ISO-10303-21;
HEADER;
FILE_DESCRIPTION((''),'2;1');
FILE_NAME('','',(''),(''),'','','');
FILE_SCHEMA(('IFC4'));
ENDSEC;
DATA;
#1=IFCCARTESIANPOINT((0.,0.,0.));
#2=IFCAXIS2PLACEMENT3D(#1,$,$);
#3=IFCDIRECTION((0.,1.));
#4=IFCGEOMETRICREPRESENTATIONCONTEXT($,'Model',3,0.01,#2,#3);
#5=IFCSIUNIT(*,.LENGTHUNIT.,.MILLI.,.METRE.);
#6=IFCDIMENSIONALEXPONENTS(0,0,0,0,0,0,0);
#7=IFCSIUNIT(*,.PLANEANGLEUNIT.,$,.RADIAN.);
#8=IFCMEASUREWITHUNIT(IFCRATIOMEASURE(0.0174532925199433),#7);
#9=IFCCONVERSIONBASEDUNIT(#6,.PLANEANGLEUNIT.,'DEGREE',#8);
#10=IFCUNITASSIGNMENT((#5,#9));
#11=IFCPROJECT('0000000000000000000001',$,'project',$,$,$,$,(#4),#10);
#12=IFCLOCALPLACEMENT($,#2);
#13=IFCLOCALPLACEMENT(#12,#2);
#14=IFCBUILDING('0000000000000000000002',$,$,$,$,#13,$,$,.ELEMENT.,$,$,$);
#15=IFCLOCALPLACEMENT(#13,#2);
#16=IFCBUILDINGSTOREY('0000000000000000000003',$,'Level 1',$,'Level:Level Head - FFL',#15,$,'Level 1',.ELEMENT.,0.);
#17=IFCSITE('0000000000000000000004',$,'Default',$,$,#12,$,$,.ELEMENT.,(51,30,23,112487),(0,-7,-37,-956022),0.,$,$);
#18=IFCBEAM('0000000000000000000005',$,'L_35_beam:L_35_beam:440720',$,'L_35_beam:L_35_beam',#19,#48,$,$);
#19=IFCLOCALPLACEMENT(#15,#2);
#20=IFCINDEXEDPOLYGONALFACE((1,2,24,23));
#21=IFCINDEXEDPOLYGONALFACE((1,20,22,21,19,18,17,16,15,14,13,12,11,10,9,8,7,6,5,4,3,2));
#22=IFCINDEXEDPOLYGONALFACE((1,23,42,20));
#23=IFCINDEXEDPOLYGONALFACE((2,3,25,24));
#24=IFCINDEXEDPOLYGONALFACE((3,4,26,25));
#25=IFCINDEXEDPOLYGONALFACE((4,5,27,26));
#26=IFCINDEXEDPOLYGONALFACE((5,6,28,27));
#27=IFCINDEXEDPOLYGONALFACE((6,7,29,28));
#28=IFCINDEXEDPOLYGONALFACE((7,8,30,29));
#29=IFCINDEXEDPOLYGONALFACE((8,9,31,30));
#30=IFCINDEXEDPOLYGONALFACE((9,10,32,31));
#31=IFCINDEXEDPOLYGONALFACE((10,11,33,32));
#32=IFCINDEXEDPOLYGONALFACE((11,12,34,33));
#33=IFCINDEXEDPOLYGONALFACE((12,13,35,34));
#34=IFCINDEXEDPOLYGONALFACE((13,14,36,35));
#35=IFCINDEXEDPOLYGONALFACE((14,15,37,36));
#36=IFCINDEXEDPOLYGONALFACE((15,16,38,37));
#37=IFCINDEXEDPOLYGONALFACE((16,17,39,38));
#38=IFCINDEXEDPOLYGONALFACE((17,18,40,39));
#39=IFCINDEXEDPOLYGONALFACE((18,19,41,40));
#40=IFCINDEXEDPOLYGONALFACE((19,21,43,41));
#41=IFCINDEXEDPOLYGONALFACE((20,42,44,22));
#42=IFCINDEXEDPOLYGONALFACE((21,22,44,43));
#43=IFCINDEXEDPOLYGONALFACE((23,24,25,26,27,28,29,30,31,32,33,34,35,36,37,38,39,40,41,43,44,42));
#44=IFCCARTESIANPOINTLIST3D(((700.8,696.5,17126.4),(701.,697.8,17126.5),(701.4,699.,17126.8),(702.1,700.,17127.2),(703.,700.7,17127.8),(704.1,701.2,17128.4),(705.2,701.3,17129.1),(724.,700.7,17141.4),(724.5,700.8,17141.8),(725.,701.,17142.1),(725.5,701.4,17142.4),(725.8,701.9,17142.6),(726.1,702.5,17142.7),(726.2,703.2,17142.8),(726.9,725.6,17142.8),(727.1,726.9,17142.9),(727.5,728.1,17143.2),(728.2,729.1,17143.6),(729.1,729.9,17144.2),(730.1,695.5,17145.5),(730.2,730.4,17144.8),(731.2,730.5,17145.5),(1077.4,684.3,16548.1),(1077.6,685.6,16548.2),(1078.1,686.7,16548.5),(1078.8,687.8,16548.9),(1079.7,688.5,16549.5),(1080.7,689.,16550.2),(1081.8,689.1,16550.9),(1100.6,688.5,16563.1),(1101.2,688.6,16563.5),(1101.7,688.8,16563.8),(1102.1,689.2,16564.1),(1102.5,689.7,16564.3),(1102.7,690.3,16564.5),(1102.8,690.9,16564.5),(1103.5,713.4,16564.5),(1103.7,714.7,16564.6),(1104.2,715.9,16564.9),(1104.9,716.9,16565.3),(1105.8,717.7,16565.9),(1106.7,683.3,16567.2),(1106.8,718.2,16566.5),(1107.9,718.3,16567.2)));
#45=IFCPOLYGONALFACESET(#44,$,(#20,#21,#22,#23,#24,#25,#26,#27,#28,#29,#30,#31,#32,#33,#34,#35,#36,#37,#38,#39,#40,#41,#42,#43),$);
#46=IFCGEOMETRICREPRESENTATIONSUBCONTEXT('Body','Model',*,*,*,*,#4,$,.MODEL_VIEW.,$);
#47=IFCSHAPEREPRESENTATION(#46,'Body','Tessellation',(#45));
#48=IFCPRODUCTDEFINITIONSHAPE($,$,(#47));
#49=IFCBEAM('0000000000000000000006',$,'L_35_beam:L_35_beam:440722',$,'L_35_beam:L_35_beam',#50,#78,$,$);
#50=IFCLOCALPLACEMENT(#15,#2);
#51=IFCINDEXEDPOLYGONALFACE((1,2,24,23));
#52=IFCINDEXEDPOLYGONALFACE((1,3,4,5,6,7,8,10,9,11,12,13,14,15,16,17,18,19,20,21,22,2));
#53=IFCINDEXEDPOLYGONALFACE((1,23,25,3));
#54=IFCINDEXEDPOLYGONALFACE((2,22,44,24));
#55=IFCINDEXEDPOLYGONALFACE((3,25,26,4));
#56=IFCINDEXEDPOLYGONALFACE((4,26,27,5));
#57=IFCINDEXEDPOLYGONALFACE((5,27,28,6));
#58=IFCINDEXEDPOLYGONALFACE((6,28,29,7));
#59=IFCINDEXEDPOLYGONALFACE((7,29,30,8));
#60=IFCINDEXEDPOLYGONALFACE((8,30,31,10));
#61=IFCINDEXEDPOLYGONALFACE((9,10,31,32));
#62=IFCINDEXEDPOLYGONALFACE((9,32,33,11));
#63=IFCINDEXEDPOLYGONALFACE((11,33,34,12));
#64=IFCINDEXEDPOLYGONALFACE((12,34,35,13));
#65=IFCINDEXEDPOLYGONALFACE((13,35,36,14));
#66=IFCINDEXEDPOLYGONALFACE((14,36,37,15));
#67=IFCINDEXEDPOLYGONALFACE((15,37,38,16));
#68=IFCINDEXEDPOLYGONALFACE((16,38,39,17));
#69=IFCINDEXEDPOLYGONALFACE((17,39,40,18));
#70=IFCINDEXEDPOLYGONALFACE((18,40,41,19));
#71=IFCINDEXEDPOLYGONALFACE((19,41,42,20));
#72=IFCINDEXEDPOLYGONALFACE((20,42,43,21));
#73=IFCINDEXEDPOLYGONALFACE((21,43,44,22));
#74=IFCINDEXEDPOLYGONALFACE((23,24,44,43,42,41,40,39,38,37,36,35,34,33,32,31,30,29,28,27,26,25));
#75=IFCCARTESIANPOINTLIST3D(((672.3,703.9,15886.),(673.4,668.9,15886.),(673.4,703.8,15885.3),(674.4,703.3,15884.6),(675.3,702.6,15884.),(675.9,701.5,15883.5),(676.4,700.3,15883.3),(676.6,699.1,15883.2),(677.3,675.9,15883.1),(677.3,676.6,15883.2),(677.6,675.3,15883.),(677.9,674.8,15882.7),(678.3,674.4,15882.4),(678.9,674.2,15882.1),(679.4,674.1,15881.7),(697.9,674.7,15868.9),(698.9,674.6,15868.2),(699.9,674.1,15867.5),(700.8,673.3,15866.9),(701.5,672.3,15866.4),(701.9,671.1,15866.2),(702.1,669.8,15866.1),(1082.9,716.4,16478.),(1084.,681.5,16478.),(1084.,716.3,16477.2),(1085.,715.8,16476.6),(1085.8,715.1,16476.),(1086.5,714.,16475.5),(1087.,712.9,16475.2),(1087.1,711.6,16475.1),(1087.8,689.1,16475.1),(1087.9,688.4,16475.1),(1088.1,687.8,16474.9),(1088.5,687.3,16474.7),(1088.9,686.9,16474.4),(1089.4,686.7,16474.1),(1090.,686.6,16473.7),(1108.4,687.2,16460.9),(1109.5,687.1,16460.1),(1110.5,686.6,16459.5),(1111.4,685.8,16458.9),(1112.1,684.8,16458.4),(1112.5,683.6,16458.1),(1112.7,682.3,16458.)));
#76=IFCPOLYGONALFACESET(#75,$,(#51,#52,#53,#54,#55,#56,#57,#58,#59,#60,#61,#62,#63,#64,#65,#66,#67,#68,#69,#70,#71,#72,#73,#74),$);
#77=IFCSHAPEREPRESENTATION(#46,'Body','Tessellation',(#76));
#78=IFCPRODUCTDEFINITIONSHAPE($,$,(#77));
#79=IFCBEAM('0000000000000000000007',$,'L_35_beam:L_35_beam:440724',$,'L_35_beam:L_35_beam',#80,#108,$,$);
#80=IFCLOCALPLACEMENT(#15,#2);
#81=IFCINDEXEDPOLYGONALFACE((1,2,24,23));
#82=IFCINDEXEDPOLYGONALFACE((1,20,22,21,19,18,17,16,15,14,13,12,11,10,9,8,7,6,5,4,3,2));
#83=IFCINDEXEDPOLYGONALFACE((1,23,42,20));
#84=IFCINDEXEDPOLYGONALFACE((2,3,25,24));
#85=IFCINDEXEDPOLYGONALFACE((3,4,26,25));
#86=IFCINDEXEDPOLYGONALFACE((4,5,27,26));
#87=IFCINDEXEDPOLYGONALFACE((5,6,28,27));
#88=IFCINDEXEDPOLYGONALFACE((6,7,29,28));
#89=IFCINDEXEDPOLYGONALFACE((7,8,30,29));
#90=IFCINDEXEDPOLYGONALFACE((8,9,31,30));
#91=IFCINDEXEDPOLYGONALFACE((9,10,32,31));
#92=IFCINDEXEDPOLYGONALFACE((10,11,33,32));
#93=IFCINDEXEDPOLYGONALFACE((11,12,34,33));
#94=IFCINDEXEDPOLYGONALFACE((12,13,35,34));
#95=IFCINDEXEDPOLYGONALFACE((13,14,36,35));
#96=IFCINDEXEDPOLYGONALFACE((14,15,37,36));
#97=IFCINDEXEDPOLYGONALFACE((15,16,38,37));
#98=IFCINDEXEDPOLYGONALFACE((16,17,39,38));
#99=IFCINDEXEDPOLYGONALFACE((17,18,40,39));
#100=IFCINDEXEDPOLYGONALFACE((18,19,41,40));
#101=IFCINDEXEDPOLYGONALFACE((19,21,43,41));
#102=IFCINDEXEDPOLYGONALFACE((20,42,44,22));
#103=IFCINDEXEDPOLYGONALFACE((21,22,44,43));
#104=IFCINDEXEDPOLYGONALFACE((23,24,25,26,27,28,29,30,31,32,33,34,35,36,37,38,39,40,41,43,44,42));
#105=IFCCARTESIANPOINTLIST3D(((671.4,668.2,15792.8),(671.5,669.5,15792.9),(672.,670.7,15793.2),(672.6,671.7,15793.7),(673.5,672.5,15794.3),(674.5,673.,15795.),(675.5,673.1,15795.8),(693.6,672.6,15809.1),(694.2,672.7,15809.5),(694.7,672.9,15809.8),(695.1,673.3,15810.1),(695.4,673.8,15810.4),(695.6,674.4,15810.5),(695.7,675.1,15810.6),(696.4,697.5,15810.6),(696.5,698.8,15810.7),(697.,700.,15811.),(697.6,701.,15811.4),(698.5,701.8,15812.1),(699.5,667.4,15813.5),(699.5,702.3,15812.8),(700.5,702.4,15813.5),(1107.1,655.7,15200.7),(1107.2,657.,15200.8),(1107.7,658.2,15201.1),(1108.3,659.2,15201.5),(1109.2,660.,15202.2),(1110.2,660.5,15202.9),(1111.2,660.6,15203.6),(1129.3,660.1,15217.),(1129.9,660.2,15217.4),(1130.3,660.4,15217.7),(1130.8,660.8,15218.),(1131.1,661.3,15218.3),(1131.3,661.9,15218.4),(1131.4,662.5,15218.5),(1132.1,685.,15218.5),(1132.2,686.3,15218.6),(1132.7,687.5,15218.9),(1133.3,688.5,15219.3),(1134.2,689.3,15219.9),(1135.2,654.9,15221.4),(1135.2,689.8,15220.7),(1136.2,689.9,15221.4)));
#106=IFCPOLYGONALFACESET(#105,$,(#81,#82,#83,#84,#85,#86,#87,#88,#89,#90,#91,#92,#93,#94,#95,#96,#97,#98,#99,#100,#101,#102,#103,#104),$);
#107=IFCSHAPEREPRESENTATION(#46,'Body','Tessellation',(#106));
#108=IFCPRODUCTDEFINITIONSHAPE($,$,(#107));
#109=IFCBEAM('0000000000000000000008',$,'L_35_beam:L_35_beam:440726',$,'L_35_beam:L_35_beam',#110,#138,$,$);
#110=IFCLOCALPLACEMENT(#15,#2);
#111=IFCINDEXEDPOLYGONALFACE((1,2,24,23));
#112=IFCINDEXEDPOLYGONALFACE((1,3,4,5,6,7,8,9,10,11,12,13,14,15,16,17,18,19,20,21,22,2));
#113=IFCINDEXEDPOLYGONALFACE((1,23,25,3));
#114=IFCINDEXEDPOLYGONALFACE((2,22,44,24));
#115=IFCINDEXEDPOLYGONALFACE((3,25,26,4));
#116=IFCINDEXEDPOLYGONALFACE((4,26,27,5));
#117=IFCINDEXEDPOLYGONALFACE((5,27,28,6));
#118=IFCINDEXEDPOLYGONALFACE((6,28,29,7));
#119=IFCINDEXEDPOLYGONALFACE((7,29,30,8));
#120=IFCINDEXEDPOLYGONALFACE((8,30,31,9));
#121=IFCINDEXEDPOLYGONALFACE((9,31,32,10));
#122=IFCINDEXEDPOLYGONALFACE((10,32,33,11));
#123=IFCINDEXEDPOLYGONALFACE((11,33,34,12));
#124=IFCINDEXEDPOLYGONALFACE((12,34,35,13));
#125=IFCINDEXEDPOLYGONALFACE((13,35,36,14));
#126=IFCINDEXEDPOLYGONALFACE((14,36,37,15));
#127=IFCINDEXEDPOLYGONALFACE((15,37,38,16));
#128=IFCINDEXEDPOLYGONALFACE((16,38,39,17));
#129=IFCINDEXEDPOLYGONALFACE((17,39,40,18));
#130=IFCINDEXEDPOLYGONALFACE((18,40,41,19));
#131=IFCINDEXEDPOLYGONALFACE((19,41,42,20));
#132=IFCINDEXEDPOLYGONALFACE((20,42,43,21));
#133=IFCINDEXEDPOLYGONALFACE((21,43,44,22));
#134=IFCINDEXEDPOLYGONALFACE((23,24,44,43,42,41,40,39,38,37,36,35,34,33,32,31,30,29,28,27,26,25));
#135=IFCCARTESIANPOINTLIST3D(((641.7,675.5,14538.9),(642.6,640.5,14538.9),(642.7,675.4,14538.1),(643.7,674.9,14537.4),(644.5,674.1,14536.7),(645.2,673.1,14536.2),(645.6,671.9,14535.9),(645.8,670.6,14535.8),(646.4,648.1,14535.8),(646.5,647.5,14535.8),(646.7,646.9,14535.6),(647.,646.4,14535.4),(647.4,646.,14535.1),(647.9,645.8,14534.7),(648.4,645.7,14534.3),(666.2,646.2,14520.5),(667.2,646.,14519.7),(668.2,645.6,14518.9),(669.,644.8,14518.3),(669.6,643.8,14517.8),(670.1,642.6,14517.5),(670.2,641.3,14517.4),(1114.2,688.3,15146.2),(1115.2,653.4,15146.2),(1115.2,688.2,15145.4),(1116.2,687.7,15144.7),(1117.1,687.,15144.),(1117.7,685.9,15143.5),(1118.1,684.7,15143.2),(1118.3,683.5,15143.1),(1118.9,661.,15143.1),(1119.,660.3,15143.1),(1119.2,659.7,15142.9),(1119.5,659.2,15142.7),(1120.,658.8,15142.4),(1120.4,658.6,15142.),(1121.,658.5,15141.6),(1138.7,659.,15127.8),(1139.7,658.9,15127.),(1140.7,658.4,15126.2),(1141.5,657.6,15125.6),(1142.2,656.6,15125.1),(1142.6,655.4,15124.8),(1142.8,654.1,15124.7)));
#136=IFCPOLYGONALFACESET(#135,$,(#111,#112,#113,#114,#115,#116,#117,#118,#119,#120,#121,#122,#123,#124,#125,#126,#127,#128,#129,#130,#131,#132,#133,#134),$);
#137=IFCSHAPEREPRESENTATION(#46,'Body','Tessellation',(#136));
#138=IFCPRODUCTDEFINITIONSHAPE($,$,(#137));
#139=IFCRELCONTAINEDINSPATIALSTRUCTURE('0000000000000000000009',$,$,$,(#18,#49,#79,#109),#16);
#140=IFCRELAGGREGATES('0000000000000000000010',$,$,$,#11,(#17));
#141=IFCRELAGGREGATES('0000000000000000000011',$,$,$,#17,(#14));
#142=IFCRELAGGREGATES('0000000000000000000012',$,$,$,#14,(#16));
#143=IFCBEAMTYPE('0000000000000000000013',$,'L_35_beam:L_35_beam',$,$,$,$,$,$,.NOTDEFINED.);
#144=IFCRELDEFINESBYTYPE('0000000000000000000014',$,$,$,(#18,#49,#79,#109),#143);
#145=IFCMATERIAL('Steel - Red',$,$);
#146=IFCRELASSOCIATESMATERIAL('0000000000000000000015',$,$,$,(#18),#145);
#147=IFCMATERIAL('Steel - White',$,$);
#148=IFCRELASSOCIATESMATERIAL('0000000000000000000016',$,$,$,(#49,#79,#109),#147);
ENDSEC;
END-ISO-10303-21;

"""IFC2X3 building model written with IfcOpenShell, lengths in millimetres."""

from ifc_helpers import new_model, entity, si_unit, converted_unit, direction, frame, frame_2d, origin, place, context, subcontext, project, spatial, polyline, circle_curve, parameter, trimmed, segment, composite_curve, outline, extrude, material, type_object, element, save


model = new_model("IFC2X3")

# Units and contexts
model_context = context("Model", 3, precision=0.01, world=origin(), true_north=direction((0.0, 1.0)))
body_context = subcontext(model_context, "Body", "Model", "MODEL_VIEW")
ifc_project = project(units=[si_unit("LENGTHUNIT", "METRE", prefix="MILLI"), converted_unit("PLANEANGLEUNIT", "DEGREE", entity("IfcRatioMeasure", 0.0174532925199433), si_unit("PLANEANGLEUNIT", "RADIAN"), dimensions=[0, 0, 0, 0, 0, 0, 0])], contexts=[model_context])

# Site, building, storey
site_placement = place(None, origin())
site = spatial("IfcSite", under=ifc_project, at=site_placement, Name="Default", CompositionType="ELEMENT", RefLatitude=(51, 30, 23, 112487), RefLongitude=(0, -7, -37, -956022), RefElevation=0.0)
building_placement = place(site_placement, origin())
building = spatial("IfcBuilding", under=site, at=building_placement, CompositionType="ELEMENT")
storey_placement = place(building_placement, origin())
storey = spatial("IfcBuildingStorey", under=building, at=storey_placement, Name="Level 1", ObjectType="Level:Level Head - FFL", LongName="Level 1", CompositionType="ELEMENT", Elevation=0.0)

# Beams
ifc_material_1 = material(Name="Steel - Red")
ifc_material_2 = material(Name="Steel - White")
beam_type_1 = type_object("IfcBeamType", Name="L_35_beam:L_35_beam", PredefinedType="NOTDEFINED")
beam_1_placement = place(storey_placement, frame((1125.2, 674.7, 16506.4), z_axis=(0.837999, 0.011527, 0.54555), x_axis=(-0.545672, 0.017703, 0.837812)))
element("IfcBeam", 1, at=beam_1_placement, inside=storey, type_object=beam_type_1, material=ifc_material_1, Name="L_35_beam:L_35_beam:440720", ObjectType="L_35_beam:L_35_beam", context=body_context, shape_type="SweptSolid", body=[
    extrude(outline(composite_curve([segment(polyline([(-23.2, -11.8), (11.8, -11.8)]), True, "CONTINUOUS"), segment(polyline([(11.8, -11.8), (11.8, 23.2)]), True, "CONTINUOUS"), segment(trimmed(circle_curve(frame_2d((11.8, 18.2), x_axis=(0.0, 1.0)), 5.0), [parameter(0.0)], [parameter(90.0)], True, "PARAMETER"), True, "CONTINUOUS"), segment(polyline([(6.8, 18.2), (6.8, -4.3)]), True, "CONTINUOUS"), segment(trimmed(circle_curve(frame_2d((4.3, -4.3), x_axis=(1.0, 0.0)), 2.5), [parameter(270.0)], [parameter(0.0)], True, "PARAMETER"), False, "CONTINUOUS"), segment(polyline([(4.3, -6.8), (-18.2, -6.8)]), True, "CONTINUOUS"), segment(trimmed(circle_curve(frame_2d((-18.2, -11.8), x_axis=(0.0, 1.0)), 5.0), [parameter(0.0)], [parameter(90.0)], True, "PARAMETER"), True, "CONTINUOUS")], self_intersect=False)), frame((61.2, -19.5, 6.5), z_axis=(1.0, 0.0, 0.0), x_axis=(0.0, 0.038693, 0.999251)), (0.0, 0.0, 1.0), 690.2),
])
beam_2_placement = place(storey_placement, frame((1125.2, 674.7, 16506.4), z_axis=(0.821764, -0.012037, -0.5697), x_axis=(-0.569827, -0.01736, -0.821581)))
element("IfcBeam", 2, at=beam_2_placement, inside=storey, type_object=beam_type_1, material=ifc_material_2, Name="L_35_beam:L_35_beam:440722", ObjectType="L_35_beam:L_35_beam", context=body_context, shape_type="SweptSolid", body=[
    extrude(outline(composite_curve([segment(polyline([(-4.3, 6.8), (18.2, 6.8)]), True, "CONTINUOUS"), segment(trimmed(circle_curve(frame_2d((18.2, 11.8), x_axis=(0.0, -1.0)), 5.0), [parameter(0.0)], [parameter(90.0)], True, "PARAMETER"), True, "CONTINUOUS"), segment(polyline([(23.2, 11.8), (-11.8, 11.8)]), True, "CONTINUOUS"), segment(polyline([(-11.8, 11.8), (-11.8, -23.2)]), True, "CONTINUOUS"), segment(trimmed(circle_curve(frame_2d((-11.8, -18.2), x_axis=(0.0, -1.0)), 5.0), [parameter(0.0)], [parameter(90.0)], True, "PARAMETER"), True, "CONTINUOUS"), segment(polyline([(-6.8, -18.2), (-6.8, 4.3)]), True, "CONTINUOUS"), segment(trimmed(circle_curve(frame_2d((-4.3, 4.3), x_axis=(-1.0, 0.0)), 2.5), [parameter(270.0)], [parameter(0.0)], True, "PARAMETER"), False, "CONTINUOUS")], self_intersect=False)), frame((46.8, 19.6, -6.4), z_axis=(1.0, 0.0, 0.0), x_axis=(0.0, 0.037055, 0.999313)), (0.0, 0.0, 1.0), 720.5),
])
beam_3_placement = place(storey_placement, frame((1153.5, 646.4, 15166.7), z_axis=(0.805503, 0.012518, 0.592459), x_axis=(-0.592591, 0.017016, 0.805324)))
element("IfcBeam", 3, at=beam_3_placement, inside=storey, type_object=beam_type_1, material=ifc_material_2, Name="L_35_beam:L_35_beam:440724", ObjectType="L_35_beam:L_35_beam", context=body_context, shape_type="SweptSolid", body=[
    extrude(outline(composite_curve([segment(polyline([(-23.2, -11.8), (11.8, -11.8)]), True, "CONTINUOUS"), segment(polyline([(11.8, -11.8), (11.8, 23.2)]), True, "CONTINUOUS"), segment(trimmed(circle_curve(frame_2d((11.8, 18.2), x_axis=(0.0, 1.0)), 5.0), [parameter(0.0)], [parameter(90.0)], True, "PARAMETER"), True, "CONTINUOUS"), segment(polyline([(6.8, 18.2), (6.8, -4.3)]), True, "CONTINUOUS"), segment(trimmed(circle_curve(frame_2d((4.3, -4.3), x_axis=(1.0, 0.0)), 2.5), [parameter(270.0)], [parameter(0.0)], True, "PARAMETER"), False, "CONTINUOUS"), segment(polyline([(4.3, -6.8), (-18.2, -6.8)]), True, "CONTINUOUS"), segment(trimmed(circle_curve(frame_2d((-18.2, -11.8), x_axis=(0.0, 1.0)), 5.0), [parameter(0.0)], [parameter(90.0)], True, "PARAMETER"), True, "CONTINUOUS")], self_intersect=False)), frame((55.0, -19.6, 6.4), z_axis=(1.0, 0.0, 0.0), x_axis=(0.0, 0.035633, 0.999365)), (0.0, 0.0, 1.0), 735.2),
])
beam_4_placement = place(storey_placement, frame((1153.5, 646.4, 15166.7), z_axis=(0.789291, -0.012971, -0.613882), x_axis=(-0.614019, -0.016674, -0.789115)))
element("IfcBeam", 4, at=beam_4_placement, inside=storey, type_object=beam_type_1, material=ifc_material_2, Name="L_35_beam:L_35_beam:440726", ObjectType="L_35_beam:L_35_beam", context=body_context, shape_type="SweptSolid", body=[
    extrude(outline(composite_curve([segment(polyline([(-4.3, 6.8), (18.2, 6.8)]), True, "CONTINUOUS"), segment(trimmed(circle_curve(frame_2d((18.2, 11.8), x_axis=(0.0, -1.0)), 5.0), [parameter(0.0)], [parameter(90.0)], True, "PARAMETER"), True, "CONTINUOUS"), segment(polyline([(23.2, 11.8), (-11.8, 11.8)]), True, "CONTINUOUS"), segment(polyline([(-11.8, 11.8), (-11.8, -23.2)]), True, "CONTINUOUS"), segment(trimmed(circle_curve(frame_2d((-11.8, -18.2), x_axis=(0.0, -1.0)), 5.0), [parameter(0.0)], [parameter(90.0)], True, "PARAMETER"), True, "CONTINUOUS"), segment(polyline([(-6.8, -18.2), (-6.8, 4.3)]), True, "CONTINUOUS"), segment(trimmed(circle_curve(frame_2d((-4.3, 4.3), x_axis=(-1.0, 0.0)), 2.5), [parameter(270.0)], [parameter(0.0)], True, "PARAMETER"), False, "CONTINUOUS")], self_intersect=False)), frame((39.6, 19.6, -6.4), z_axis=(1.0, 0.0, 0.0), x_axis=(0.0, 0.034391, 0.999408)), (0.0, 0.0, 1.0), 769.6),
])

save(model, "model.ifc")
